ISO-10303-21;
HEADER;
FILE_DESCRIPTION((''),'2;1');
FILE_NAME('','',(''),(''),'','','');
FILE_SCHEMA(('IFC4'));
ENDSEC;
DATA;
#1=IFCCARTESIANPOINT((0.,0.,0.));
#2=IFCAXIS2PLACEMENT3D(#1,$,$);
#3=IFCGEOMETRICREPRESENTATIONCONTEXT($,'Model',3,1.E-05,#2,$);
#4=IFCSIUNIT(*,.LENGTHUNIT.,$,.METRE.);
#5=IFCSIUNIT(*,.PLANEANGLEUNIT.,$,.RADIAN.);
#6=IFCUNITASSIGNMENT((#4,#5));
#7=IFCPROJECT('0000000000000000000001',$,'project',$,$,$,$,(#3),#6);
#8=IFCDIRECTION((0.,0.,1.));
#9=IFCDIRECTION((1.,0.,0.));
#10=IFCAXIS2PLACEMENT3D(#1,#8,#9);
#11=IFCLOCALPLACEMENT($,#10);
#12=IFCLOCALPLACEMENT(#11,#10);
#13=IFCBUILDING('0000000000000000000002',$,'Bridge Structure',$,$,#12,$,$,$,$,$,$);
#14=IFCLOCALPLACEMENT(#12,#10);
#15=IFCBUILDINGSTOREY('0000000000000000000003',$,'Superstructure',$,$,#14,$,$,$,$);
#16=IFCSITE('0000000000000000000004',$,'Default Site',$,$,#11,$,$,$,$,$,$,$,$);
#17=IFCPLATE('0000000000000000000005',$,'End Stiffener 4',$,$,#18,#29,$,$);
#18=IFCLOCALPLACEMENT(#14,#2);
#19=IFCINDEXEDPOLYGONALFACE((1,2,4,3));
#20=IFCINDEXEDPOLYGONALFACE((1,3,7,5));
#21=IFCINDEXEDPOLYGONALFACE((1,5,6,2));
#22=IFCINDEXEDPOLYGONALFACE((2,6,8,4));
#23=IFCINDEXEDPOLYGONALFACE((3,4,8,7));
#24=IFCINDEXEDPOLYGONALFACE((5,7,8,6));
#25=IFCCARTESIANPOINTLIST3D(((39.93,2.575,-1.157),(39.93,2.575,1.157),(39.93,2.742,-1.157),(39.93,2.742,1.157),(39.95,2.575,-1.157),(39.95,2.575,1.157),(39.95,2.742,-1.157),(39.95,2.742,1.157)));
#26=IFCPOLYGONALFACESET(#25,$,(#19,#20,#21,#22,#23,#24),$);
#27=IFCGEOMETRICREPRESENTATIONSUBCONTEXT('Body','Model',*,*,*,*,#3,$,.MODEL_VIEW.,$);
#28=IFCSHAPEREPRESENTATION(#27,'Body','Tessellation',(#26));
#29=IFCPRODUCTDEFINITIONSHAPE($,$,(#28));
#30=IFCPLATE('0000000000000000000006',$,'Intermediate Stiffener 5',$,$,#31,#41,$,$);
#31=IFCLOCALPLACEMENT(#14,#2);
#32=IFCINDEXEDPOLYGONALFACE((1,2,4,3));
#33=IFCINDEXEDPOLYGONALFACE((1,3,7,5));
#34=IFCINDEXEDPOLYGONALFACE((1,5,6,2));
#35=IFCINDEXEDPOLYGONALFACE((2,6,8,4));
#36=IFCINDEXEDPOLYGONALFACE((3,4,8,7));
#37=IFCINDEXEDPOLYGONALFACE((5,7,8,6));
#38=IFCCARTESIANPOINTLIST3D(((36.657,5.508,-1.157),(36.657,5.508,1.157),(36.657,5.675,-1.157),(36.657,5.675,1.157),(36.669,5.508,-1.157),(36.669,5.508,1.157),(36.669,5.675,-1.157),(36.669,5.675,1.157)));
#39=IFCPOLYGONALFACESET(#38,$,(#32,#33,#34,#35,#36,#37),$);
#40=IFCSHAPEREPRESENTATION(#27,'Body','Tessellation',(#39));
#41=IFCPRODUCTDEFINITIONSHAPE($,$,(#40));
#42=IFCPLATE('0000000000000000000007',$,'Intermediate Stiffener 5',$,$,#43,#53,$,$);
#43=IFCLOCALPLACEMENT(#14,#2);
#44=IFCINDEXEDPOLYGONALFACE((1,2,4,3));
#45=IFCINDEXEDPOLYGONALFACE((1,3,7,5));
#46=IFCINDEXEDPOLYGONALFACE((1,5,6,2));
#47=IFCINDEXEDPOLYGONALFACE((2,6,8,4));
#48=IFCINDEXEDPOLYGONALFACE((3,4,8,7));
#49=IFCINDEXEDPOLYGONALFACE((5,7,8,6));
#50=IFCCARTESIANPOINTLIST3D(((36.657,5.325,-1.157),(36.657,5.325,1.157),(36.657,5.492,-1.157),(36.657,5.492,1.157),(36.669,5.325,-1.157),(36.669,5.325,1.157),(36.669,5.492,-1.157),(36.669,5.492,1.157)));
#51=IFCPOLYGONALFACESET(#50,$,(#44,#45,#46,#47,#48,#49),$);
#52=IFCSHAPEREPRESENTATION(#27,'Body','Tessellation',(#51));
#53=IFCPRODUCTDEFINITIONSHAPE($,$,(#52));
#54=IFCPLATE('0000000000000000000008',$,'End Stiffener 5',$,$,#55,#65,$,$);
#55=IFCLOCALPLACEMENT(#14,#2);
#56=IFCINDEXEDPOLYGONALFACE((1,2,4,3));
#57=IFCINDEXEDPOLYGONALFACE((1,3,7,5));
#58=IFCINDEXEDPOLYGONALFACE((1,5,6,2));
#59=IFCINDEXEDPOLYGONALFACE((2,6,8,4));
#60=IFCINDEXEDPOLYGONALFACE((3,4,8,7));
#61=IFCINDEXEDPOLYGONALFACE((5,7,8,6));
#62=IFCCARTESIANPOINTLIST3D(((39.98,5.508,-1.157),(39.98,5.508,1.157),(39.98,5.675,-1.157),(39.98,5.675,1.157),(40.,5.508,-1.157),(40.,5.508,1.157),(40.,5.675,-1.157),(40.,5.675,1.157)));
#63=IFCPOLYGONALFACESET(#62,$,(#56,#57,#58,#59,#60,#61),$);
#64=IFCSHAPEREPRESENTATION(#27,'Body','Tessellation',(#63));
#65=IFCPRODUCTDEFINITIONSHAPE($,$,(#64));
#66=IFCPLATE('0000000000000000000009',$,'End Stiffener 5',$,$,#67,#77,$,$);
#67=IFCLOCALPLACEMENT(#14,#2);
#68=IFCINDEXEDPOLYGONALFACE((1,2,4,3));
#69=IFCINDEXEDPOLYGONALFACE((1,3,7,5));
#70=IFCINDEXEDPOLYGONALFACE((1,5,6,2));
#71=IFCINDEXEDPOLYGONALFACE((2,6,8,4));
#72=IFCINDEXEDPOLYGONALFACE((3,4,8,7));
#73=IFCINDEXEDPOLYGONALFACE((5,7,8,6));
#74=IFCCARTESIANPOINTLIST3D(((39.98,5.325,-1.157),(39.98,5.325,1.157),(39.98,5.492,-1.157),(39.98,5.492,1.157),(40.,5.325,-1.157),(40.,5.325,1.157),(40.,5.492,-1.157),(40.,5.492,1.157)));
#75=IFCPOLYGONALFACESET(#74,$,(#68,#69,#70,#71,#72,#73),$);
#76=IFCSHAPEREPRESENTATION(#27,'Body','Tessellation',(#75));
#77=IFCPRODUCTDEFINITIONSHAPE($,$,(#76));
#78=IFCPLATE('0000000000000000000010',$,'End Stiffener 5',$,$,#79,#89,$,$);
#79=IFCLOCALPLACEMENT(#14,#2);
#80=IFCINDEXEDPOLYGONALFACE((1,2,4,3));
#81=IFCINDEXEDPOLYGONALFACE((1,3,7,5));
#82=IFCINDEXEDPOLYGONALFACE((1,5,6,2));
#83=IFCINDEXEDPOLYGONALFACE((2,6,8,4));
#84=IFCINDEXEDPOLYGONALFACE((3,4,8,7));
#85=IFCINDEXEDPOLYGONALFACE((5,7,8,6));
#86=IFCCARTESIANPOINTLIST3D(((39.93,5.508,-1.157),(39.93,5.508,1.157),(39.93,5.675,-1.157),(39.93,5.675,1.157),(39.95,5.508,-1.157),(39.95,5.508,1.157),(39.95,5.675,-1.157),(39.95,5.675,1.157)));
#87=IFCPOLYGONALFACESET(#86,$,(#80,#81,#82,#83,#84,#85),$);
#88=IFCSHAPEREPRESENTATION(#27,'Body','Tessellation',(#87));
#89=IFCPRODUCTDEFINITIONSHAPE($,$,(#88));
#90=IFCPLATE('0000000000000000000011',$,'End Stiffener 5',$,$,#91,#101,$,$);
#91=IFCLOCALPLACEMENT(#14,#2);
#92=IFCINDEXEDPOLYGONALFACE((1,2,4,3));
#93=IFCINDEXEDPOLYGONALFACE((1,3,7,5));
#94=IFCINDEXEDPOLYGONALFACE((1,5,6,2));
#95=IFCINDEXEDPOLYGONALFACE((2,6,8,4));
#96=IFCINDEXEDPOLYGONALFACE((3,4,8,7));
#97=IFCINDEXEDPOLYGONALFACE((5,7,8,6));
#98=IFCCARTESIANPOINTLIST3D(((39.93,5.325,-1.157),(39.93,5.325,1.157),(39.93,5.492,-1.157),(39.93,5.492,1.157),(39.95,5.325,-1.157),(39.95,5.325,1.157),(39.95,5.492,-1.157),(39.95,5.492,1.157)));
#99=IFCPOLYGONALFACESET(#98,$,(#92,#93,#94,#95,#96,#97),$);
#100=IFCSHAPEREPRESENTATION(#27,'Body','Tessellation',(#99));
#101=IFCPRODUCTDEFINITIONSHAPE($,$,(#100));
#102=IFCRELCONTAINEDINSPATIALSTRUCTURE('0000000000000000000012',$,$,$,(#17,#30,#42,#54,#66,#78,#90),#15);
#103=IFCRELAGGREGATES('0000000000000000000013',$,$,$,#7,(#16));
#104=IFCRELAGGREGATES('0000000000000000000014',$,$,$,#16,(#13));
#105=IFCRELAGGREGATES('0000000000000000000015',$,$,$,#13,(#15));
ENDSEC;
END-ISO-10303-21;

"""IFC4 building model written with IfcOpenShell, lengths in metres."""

from ifc_helpers import new_model, si_unit, frame, origin, origin_with_axes, origin_2d_with_axis, place, context, subcontext, project, spatial, rectangle, extrude, element, save


model = new_model("IFC4")

# Units and contexts
model_context = context("Model", 3, precision=1e-05, world=origin())
body_context = subcontext(model_context, "Body", "Model", "MODEL_VIEW")
ifc_project = project(units=[si_unit("LENGTHUNIT", "METRE"), si_unit("PLANEANGLEUNIT", "RADIAN")], contexts=[model_context])

# Site, building, storey
site_placement = place(None, origin_with_axes())
site = spatial("IfcSite", under=ifc_project, at=site_placement, Name="Default Site")
building_placement = place(site_placement, origin_with_axes())
building = spatial("IfcBuilding", under=site, at=building_placement, Name="Bridge Structure")
storey_placement = place(building_placement, origin_with_axes())
storey = spatial("IfcBuildingStorey", under=building, at=storey_placement, Name="Superstructure")

# Plates
for number, where, z_axis, x_axis, name in (
    (1, (39.94, 2.6585, -1.157), (0.0, 0.0, 1.0), (1.0, 0.0, 0.0), "End Stiffener 4"),
):
    element("IfcPlate", number, at=place(storey_placement, frame(where, z_axis=z_axis, x_axis=x_axis)), inside=storey, Name=name, context=body_context, shape_type="SweptSolid", body=[
        extrude(rectangle(XDim=0.02, YDim=0.167, at=origin_2d_with_axis()), origin_with_axes(), (0.0, 0.0, 1.0), 2.314),
    ])
for number, where, z_axis, x_axis, name in (
    (2, (36.663, 5.5915, -1.157), (0.0, 0.0, 1.0), (1.0, 0.0, 0.0), "Intermediate Stiffener 5"),
    (3, (36.663, 5.4085, -1.157), (0.0, 0.0, 1.0), (1.0, 0.0, 0.0), "Intermediate Stiffener 5"),
):
    element("IfcPlate", number, at=place(storey_placement, frame(where, z_axis=z_axis, x_axis=x_axis)), inside=storey, Name=name, context=body_context, shape_type="SweptSolid", body=[
        extrude(rectangle(XDim=0.012, YDim=0.167, at=origin_2d_with_axis()), origin_with_axes(), (0.0, 0.0, 1.0), 2.314),
    ])
for number, where, z_axis, x_axis, name in (
    (4, (39.99, 5.5915, -1.157), (0.0, 0.0, 1.0), (1.0, 0.0, 0.0), "End Stiffener 5"),
    (5, (39.99, 5.4085, -1.157), (0.0, 0.0, 1.0), (1.0, 0.0, 0.0), "End Stiffener 5"),
    (6, (39.94, 5.5915, -1.157), (0.0, 0.0, 1.0), (1.0, 0.0, 0.0), "End Stiffener 5"),
    (7, (39.94, 5.4085, -1.157), (0.0, 0.0, 1.0), (1.0, 0.0, 0.0), "End Stiffener 5"),
):
    element("IfcPlate", number, at=place(storey_placement, frame(where, z_axis=z_axis, x_axis=x_axis)), inside=storey, Name=name, context=body_context, shape_type="SweptSolid", body=[
        extrude(rectangle(XDim=0.02, YDim=0.167, at=origin_2d_with_axis()), origin_with_axes(), (0.0, 0.0, 1.0), 2.314),
    ])

save(model, "model.ifc")
